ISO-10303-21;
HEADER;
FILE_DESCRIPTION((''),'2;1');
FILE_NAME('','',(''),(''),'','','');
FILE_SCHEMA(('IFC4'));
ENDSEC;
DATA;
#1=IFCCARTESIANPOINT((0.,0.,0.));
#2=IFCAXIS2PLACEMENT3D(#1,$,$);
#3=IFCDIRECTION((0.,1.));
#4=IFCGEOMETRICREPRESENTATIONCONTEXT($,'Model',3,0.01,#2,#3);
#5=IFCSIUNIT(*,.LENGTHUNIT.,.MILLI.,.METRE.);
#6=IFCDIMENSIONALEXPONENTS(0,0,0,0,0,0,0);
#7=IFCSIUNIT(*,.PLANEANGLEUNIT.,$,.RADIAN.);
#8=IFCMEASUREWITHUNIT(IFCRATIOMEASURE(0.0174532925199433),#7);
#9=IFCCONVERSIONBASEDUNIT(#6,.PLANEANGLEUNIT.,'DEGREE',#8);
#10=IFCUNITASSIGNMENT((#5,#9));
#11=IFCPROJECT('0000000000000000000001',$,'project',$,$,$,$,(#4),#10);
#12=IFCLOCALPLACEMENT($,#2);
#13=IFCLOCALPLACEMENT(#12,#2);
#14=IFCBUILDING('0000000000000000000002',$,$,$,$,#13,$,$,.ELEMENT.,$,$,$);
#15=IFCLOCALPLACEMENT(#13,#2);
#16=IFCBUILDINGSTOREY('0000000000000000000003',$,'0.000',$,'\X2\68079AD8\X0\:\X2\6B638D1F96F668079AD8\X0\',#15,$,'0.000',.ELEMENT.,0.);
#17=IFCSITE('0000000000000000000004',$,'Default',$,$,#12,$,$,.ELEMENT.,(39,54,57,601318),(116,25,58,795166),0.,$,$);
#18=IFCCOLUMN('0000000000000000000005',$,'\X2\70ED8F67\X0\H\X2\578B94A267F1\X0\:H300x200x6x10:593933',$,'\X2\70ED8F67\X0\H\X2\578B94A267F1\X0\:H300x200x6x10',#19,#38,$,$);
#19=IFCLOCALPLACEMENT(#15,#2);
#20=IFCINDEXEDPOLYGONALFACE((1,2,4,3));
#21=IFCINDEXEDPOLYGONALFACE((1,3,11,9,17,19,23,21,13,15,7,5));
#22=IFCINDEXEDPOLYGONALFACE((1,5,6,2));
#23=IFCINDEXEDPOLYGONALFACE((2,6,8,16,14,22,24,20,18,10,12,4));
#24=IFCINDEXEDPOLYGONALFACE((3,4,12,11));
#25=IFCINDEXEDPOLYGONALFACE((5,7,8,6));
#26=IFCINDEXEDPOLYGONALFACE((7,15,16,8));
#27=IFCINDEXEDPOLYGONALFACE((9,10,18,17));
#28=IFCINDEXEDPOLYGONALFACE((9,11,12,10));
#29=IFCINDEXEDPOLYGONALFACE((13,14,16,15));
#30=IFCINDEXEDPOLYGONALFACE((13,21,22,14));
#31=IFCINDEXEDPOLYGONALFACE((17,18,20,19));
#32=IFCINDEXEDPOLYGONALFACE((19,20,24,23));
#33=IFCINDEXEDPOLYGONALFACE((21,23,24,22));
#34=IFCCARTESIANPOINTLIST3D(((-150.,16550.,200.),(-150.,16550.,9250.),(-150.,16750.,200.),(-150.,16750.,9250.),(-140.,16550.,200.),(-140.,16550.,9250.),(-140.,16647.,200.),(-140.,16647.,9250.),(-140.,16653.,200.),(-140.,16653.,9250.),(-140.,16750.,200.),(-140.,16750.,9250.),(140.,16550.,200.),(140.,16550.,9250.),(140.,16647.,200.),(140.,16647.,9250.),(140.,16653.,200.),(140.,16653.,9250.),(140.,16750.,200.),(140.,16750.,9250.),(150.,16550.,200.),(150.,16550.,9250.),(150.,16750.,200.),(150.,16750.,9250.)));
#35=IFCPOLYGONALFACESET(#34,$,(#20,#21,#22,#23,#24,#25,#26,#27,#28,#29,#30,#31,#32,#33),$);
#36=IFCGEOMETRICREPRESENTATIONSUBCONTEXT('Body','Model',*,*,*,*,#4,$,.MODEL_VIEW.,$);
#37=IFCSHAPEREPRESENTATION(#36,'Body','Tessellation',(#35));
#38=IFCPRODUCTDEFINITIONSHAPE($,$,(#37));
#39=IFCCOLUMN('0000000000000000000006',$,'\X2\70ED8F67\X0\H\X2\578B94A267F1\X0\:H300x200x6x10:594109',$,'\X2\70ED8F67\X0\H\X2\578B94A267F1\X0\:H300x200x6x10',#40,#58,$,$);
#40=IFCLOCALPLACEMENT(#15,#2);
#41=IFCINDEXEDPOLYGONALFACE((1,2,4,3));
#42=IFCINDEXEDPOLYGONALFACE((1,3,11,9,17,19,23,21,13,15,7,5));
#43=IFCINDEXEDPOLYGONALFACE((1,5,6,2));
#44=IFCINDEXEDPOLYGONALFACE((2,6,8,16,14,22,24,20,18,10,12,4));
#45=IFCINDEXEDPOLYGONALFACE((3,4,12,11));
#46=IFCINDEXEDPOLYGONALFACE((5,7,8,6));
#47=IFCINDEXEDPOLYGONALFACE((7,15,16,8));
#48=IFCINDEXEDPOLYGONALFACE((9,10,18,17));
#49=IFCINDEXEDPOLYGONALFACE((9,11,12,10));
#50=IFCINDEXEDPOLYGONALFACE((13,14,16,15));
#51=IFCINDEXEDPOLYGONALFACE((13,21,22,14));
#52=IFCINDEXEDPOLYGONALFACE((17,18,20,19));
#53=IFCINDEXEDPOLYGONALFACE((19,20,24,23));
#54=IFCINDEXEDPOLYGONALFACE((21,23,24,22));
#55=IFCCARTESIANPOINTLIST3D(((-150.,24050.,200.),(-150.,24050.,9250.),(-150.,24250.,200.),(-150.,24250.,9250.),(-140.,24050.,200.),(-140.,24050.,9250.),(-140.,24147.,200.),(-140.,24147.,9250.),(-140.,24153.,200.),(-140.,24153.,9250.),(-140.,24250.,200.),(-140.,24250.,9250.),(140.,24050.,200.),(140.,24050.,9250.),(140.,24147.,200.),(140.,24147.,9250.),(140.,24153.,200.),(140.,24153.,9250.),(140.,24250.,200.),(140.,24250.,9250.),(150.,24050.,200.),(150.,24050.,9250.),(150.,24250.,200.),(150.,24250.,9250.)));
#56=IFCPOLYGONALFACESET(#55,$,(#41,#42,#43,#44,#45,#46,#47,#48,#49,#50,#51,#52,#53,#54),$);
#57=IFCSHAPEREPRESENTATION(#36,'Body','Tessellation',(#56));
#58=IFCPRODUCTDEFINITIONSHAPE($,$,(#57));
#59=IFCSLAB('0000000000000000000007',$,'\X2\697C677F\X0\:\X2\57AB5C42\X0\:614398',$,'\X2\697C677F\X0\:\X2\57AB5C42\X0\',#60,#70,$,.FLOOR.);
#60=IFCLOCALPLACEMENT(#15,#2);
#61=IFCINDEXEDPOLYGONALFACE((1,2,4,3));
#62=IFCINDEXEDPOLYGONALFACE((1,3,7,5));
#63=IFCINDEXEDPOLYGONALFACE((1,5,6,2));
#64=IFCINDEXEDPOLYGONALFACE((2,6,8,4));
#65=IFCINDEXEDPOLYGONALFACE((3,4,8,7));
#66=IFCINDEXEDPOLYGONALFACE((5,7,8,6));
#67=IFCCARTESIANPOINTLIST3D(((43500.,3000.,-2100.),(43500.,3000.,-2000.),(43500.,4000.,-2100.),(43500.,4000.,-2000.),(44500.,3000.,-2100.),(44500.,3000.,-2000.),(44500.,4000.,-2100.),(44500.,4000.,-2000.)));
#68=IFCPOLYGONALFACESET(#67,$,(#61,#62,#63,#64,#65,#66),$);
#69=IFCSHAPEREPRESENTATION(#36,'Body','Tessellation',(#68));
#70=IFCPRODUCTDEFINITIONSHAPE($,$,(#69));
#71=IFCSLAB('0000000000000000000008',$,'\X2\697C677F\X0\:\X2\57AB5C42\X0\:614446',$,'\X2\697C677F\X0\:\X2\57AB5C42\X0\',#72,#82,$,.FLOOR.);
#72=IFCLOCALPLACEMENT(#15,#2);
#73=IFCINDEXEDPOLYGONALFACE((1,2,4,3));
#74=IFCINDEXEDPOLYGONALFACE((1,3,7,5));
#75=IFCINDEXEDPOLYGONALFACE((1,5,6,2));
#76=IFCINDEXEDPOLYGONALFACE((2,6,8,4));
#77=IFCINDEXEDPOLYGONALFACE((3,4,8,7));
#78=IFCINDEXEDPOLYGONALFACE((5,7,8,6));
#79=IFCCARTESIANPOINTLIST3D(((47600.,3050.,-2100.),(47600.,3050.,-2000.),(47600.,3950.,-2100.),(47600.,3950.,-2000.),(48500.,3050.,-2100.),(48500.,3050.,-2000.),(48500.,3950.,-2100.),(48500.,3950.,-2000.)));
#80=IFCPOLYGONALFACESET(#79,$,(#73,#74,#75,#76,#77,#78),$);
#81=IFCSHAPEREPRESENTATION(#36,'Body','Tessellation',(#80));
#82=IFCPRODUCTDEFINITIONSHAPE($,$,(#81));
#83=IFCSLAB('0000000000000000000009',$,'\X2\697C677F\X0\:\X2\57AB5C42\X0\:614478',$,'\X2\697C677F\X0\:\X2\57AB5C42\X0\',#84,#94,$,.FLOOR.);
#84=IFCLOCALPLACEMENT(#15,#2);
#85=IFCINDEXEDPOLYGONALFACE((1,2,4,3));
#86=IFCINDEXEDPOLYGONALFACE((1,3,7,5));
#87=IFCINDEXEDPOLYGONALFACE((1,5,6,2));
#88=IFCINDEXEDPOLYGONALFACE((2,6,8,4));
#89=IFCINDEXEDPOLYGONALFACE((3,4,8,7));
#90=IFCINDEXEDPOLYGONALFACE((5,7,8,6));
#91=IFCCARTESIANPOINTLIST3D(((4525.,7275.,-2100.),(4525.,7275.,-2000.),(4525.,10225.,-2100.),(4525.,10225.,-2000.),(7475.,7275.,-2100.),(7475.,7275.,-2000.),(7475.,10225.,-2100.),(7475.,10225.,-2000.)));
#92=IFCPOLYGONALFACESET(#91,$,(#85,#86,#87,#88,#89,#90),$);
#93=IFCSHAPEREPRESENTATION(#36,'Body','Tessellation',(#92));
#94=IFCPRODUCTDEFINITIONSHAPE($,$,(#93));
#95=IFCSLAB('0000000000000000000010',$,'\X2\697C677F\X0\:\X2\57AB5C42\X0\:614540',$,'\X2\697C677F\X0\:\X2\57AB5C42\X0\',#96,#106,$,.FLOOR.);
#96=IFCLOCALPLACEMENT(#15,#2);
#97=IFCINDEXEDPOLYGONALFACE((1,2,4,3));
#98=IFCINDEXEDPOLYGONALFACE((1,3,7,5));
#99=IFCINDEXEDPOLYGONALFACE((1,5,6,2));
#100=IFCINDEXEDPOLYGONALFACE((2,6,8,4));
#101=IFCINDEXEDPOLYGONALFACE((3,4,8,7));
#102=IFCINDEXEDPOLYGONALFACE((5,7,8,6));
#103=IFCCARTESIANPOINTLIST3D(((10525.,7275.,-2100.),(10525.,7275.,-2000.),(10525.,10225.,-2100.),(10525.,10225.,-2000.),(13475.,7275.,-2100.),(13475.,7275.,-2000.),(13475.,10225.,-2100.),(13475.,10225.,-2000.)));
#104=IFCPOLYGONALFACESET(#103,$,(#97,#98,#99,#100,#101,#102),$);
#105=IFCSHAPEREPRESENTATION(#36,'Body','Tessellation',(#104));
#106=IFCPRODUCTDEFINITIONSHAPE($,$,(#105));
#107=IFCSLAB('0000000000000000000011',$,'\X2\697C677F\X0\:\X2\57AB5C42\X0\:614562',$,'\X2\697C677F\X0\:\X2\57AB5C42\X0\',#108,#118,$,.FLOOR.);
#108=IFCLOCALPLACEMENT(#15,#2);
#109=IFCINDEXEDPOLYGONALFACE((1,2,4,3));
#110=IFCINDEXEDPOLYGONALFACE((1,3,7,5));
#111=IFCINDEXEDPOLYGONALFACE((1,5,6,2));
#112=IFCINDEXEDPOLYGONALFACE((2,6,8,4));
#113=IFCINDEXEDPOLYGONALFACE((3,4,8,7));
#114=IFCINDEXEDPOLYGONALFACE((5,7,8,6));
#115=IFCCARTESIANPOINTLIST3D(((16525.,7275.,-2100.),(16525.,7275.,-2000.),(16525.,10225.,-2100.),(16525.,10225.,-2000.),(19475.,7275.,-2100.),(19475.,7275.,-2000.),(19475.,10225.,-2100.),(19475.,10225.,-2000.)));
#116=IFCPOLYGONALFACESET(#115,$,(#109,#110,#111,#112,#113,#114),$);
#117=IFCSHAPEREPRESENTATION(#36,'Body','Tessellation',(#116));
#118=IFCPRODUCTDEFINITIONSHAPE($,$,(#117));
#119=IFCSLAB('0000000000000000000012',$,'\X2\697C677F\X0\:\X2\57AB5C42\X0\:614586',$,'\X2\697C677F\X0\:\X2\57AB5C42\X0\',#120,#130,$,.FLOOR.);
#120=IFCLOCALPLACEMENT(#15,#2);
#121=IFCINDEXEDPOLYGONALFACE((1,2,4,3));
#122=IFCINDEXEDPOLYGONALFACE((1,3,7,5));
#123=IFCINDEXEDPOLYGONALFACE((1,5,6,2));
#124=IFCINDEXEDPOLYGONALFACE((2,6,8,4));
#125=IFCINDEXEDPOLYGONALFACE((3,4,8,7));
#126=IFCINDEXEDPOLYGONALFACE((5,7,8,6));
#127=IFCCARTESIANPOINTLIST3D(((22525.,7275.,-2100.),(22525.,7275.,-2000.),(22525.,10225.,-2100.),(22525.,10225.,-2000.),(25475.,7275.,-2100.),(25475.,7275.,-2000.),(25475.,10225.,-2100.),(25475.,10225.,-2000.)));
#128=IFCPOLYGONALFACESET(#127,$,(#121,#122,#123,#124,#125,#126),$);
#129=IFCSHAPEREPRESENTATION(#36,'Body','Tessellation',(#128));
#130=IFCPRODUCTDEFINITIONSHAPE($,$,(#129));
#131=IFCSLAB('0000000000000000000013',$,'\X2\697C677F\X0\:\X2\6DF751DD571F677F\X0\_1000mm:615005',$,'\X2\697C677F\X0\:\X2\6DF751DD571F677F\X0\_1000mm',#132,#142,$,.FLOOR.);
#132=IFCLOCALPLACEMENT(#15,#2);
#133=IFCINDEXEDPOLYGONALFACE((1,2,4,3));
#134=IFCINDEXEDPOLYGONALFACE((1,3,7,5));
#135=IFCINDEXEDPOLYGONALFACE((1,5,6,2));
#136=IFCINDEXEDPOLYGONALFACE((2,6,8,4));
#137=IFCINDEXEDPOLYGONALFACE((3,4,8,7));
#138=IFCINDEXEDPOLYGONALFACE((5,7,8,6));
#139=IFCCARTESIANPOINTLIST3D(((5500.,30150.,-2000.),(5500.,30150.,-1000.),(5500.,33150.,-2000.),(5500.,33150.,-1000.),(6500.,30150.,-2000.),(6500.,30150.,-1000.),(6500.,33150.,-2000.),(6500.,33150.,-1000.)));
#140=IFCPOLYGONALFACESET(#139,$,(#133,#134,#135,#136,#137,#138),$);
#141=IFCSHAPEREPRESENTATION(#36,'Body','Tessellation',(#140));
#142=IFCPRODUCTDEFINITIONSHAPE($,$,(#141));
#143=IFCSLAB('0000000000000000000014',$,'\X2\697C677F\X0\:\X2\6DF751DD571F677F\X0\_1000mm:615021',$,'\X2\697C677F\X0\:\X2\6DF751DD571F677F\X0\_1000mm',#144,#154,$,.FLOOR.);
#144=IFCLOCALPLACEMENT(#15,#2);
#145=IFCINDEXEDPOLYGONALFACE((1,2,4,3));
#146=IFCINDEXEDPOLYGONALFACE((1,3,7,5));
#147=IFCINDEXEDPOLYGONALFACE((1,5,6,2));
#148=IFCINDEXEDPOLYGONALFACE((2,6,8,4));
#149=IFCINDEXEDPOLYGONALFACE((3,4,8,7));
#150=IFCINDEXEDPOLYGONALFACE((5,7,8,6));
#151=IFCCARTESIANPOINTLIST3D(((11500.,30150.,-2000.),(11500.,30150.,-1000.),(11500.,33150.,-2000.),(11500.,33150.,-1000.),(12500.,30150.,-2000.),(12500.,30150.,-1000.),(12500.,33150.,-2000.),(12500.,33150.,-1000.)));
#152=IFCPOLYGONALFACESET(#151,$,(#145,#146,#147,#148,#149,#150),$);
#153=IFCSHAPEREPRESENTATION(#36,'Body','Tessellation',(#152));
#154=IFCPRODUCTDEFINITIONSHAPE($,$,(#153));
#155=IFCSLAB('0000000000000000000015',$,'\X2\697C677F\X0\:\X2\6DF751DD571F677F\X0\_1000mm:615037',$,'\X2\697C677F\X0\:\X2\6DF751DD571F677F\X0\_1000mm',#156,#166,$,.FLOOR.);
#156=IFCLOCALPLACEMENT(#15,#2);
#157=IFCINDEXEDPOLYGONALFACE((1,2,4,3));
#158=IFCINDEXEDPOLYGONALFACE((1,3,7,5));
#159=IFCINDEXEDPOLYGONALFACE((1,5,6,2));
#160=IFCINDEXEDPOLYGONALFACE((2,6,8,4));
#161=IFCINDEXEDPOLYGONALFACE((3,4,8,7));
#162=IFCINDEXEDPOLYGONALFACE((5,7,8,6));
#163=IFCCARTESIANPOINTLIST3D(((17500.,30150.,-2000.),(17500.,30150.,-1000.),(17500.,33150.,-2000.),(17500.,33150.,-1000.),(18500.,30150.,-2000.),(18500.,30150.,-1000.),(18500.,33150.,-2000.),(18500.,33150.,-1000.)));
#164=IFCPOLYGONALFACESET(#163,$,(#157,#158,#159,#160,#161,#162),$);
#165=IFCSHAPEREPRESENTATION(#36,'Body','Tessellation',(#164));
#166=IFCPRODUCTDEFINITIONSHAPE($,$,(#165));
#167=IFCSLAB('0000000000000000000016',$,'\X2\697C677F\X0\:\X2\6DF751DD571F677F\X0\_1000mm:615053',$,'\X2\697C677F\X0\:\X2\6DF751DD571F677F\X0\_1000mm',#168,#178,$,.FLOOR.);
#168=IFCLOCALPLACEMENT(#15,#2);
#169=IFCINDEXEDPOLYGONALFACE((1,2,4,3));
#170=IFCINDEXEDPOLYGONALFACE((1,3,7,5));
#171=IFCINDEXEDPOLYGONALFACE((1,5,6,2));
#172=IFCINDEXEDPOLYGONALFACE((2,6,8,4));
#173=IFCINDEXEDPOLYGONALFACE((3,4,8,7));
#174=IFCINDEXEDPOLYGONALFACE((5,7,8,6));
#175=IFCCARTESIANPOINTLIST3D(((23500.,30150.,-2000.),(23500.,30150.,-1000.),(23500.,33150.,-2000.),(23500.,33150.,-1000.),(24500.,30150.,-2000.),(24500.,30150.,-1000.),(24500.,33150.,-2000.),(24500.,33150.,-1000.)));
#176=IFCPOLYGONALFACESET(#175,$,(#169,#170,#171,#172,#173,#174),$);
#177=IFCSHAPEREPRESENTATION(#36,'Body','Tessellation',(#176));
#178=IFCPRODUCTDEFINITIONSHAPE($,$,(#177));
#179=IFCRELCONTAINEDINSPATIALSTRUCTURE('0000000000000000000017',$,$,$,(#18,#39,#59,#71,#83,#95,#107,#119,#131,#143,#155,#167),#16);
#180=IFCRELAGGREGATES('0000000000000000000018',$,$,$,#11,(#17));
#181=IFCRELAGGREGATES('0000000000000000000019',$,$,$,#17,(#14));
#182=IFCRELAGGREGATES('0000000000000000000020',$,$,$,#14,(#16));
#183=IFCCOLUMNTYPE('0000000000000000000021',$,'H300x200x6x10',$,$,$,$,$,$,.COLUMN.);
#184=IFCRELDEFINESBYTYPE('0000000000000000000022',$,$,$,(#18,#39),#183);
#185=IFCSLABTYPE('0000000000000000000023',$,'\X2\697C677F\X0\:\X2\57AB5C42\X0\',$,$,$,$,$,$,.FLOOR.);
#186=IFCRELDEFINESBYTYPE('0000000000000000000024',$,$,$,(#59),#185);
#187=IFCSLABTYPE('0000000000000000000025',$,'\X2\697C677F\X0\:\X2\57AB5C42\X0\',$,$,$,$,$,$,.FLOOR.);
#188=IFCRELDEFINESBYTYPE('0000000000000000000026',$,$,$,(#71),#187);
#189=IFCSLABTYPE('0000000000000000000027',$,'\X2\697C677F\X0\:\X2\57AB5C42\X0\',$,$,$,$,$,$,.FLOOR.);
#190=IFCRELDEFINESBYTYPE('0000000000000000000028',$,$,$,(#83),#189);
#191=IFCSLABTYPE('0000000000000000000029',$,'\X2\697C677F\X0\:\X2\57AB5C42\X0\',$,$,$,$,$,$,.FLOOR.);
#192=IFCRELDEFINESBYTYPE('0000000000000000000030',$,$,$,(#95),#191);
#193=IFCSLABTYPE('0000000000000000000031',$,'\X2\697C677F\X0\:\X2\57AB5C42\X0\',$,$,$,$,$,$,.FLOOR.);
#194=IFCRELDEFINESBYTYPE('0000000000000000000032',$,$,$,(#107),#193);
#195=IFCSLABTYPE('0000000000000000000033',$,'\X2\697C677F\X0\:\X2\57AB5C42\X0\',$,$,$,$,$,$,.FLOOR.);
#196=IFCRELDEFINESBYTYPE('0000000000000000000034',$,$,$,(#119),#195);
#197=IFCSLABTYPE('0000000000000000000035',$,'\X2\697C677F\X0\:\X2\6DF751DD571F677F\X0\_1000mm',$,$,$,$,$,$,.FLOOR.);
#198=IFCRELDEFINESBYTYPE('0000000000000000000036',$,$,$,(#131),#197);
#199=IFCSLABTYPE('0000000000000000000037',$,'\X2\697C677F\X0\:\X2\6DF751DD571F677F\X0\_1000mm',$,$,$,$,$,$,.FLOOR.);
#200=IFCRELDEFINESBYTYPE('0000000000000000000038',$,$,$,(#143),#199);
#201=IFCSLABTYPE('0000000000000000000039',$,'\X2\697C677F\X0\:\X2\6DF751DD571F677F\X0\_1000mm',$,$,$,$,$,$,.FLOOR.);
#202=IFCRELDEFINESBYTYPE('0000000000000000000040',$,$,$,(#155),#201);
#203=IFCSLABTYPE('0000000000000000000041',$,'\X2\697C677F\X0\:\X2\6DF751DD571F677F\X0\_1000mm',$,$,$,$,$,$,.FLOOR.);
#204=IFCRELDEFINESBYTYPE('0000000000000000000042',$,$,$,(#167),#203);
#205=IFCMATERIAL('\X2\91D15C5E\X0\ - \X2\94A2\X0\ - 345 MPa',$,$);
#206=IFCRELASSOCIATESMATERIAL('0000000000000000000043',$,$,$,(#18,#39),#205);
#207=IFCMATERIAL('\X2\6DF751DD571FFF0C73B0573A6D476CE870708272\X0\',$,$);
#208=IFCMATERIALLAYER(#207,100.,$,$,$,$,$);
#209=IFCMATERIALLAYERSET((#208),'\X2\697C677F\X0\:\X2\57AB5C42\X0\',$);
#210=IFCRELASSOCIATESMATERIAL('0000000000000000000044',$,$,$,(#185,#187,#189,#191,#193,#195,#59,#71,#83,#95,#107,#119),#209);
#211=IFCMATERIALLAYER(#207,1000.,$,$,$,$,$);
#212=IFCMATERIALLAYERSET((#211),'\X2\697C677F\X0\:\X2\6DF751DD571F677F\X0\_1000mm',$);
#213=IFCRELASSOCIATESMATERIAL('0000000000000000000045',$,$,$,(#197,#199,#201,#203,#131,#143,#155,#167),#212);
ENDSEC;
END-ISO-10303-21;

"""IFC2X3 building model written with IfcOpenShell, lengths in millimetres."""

from ifc_helpers import new_model, entity, si_unit, converted_unit, direction, frame, frame_2d, origin, origin_2d_with_axis, place, context, subcontext, project, spatial, polyline, rectangle, outline, extrude, source, transform, mapped, material, layer, layer_set, layer_usage, type_object, type_shapes, element, save


model = new_model("IFC2X3")

# Units and contexts
model_context = context("Model", 3, precision=0.01, world=origin(), true_north=direction((0.0, 1.0)))
body_context = subcontext(model_context, "Body", "Model", "MODEL_VIEW")
ifc_project = project(units=[si_unit("LENGTHUNIT", "METRE", prefix="MILLI"), converted_unit("PLANEANGLEUNIT", "DEGREE", entity("IfcRatioMeasure", 0.0174532925199433), si_unit("PLANEANGLEUNIT", "RADIAN"), dimensions=[0, 0, 0, 0, 0, 0, 0])], contexts=[model_context])

# Site, building, storey
site_placement = place(None, origin())
site = spatial("IfcSite", under=ifc_project, at=site_placement, Name="Default", CompositionType="ELEMENT", RefLatitude=(39, 54, 57, 601318), RefLongitude=(116, 25, 58, 795166), RefElevation=0.0)
building_placement = place(site_placement, origin())
building = spatial("IfcBuilding", under=site, at=building_placement, CompositionType="ELEMENT")
storey_placement = place(building_placement, origin())
storey = spatial("IfcBuildingStorey", under=building, at=storey_placement, Name="0.000", ObjectType="标高:正负零标高", LongName="0.000", CompositionType="ELEMENT", Elevation=0.0)

# Columns
ifc_material_1 = material(Name="金属 - 钢 - 345 MPa")
column_type_1 = type_object("IfcColumnType", Name="H300x200x6x10", PredefinedType="COLUMN")
shared_shape_1 = source(origin(), body_context, "Body", "SweptSolid", [
    extrude(outline(polyline([(140.0, -100.0), (150.0, -100.0), (150.0, 100.0), (140.0, 100.0), (140.0, 3.0), (-140.0, 3.0), (-140.0, 100.0), (-150.0, 100.0), (-150.0, -100.0), (-140.0, -100.0), (-140.0, -3.0), (140.0, -3.0), (140.0, -100.0)])), frame((0.0, 0.0, 200.0), z_axis=(0.0, 0.0, 1.0), x_axis=(0.0, -1.0, 0.0)), (0.0, 0.0, 1.0), 9050.0),
])
type_shapes(column_type_1, [shared_shape_1])
for number, where, z_axis, x_axis, name in (
    (1, (0.0, 16650.0, 0.0), (0.0, 0.0, 1.0), (0.0, 1.0, 0.0), "热轧H型钢柱:H300x200x6x10:593933"),
    (2, (0.0, 24150.0, 0.0), (0.0, 0.0, 1.0), (0.0, 1.0, 0.0), "热轧H型钢柱:H300x200x6x10:594109"),
):
    element("IfcColumn", number, at=place(storey_placement, frame(where, z_axis=z_axis, x_axis=x_axis)), inside=storey, type_object=column_type_1, material=ifc_material_1, Name=name, ObjectType="热轧H型钢柱:H300x200x6x10", context=body_context, shape_type="MappedRepresentation", body=[
        mapped(shared_shape_1, transform((0.0, 0.0, 0.0), scale=1.0)),
    ])

# Slabs
ifc_material_2 = material(Name="混凝土，现场浇注灰色")
ifc_layer_1 = layer(ifc_material_2, 100.0)
ifc_layer_set_1 = layer_set([ifc_layer_1], Name="楼板:垫层")
ifc_layer_usage_1 = layer_usage(ifc_layer_set_1, "AXIS3", "POSITIVE", 0.0)
slab_type_1 = type_object("IfcSlabType", Name="楼板:垫层", PredefinedType="FLOOR", material=ifc_layer_set_1)
slab_1_placement = place(storey_placement, origin())
element("IfcSlab", 3, at=slab_1_placement, inside=storey, type_object=slab_type_1, material=ifc_layer_usage_1, Name="楼板:垫层:614398", ObjectType="楼板:垫层", PredefinedType="FLOOR", context=body_context, shape_type="SweptSolid", body=[
    extrude(rectangle(XDim=1000.0, YDim=1000.0, at=origin_2d_with_axis()), frame((44000.0, 3500.0, -2000.0), z_axis=(0.0, 0.0, -1.0), x_axis=(0.0, 1.0, 0.0)), (0.0, 0.0, 1.0), 100.0),
])
ifc_layer_usage_2 = layer_usage(ifc_layer_set_1, "AXIS3", "POSITIVE", 0.0)
slab_type_2 = type_object("IfcSlabType", Name="楼板:垫层", PredefinedType="FLOOR", material=ifc_layer_set_1)
slab_2_placement = place(storey_placement, origin())
element("IfcSlab", 4, at=slab_2_placement, inside=storey, type_object=slab_type_2, material=ifc_layer_usage_2, Name="楼板:垫层:614446", ObjectType="楼板:垫层", PredefinedType="FLOOR", context=body_context, shape_type="SweptSolid", body=[
    extrude(rectangle(XDim=900.0, YDim=900.0, at=frame_2d((0.0, 0.0), x_axis=(1.0, 0.0))), frame((48050.0, 3500.0, -2000.0), z_axis=(0.0, 0.0, -1.0), x_axis=(0.0, 1.0, 0.0)), (0.0, 0.0, 1.0), 100.0),
])
ifc_layer_usage_3 = layer_usage(ifc_layer_set_1, "AXIS3", "POSITIVE", 0.0)
slab_type_3 = type_object("IfcSlabType", Name="楼板:垫层", PredefinedType="FLOOR", material=ifc_layer_set_1)
slab_3_placement = place(storey_placement, origin())
element("IfcSlab", 5, at=slab_3_placement, inside=storey, type_object=slab_type_3, material=ifc_layer_usage_3, Name="楼板:垫层:614478", ObjectType="楼板:垫层", PredefinedType="FLOOR", context=body_context, shape_type="SweptSolid", body=[
    extrude(rectangle(XDim=2950.0, YDim=2950.0, at=frame_2d((0.0, 0.0), x_axis=(1.0, 0.0))), frame((6000.0, 8750.0, -2000.0), z_axis=(0.0, 0.0, -1.0), x_axis=(0.0, 1.0, 0.0)), (0.0, 0.0, 1.0), 100.0),
])
ifc_layer_usage_4 = layer_usage(ifc_layer_set_1, "AXIS3", "POSITIVE", 0.0)
slab_type_4 = type_object("IfcSlabType", Name="楼板:垫层", PredefinedType="FLOOR", material=ifc_layer_set_1)
slab_4_placement = place(storey_placement, origin())
element("IfcSlab", 6, at=slab_4_placement, inside=storey, type_object=slab_type_4, material=ifc_layer_usage_4, Name="楼板:垫层:614540", ObjectType="楼板:垫层", PredefinedType="FLOOR", context=body_context, shape_type="SweptSolid", body=[
    extrude(rectangle(XDim=2950.0, YDim=2950.0, at=origin_2d_with_axis()), frame((12000.0, 8750.0, -2000.0), z_axis=(0.0, 0.0, -1.0), x_axis=(0.0, 1.0, 0.0)), (0.0, 0.0, 1.0), 100.0),
])
ifc_layer_usage_5 = layer_usage(ifc_layer_set_1, "AXIS3", "POSITIVE", 0.0)
slab_type_5 = type_object("IfcSlabType", Name="楼板:垫层", PredefinedType="FLOOR", material=ifc_layer_set_1)
slab_5_placement = place(storey_placement, origin())
element("IfcSlab", 7, at=slab_5_placement, inside=storey, type_object=slab_type_5, material=ifc_layer_usage_5, Name="楼板:垫层:614562", ObjectType="楼板:垫层", PredefinedType="FLOOR", context=body_context, shape_type="SweptSolid", body=[
    extrude(rectangle(XDim=2950.0, YDim=2950.0, at=origin_2d_with_axis()), frame((18000.0, 8750.0, -2000.0), z_axis=(0.0, 0.0, -1.0), x_axis=(0.0, 1.0, 0.0)), (0.0, 0.0, 1.0), 100.0),
])
ifc_layer_usage_6 = layer_usage(ifc_layer_set_1, "AXIS3", "POSITIVE", 0.0)
slab_type_6 = type_object("IfcSlabType", Name="楼板:垫层", PredefinedType="FLOOR", material=ifc_layer_set_1)
slab_6_placement = place(storey_placement, origin())
element("IfcSlab", 8, at=slab_6_placement, inside=storey, type_object=slab_type_6, material=ifc_layer_usage_6, Name="楼板:垫层:614586", ObjectType="楼板:垫层", PredefinedType="FLOOR", context=body_context, shape_type="SweptSolid", body=[
    extrude(rectangle(XDim=2950.0, YDim=2950.0, at=frame_2d((0.0, 0.0), x_axis=(1.0, 0.0))), frame((24000.0, 8750.0, -2000.0), z_axis=(0.0, 0.0, -1.0), x_axis=(0.0, 1.0, 0.0)), (0.0, 0.0, 1.0), 100.0),
])
ifc_layer_2 = layer(ifc_material_2, 1000.0)
ifc_layer_set_2 = layer_set([ifc_layer_2], Name="楼板:混凝土板_1000mm")
ifc_layer_usage_7 = layer_usage(ifc_layer_set_2, "AXIS3", "POSITIVE", 0.0)
slab_type_7 = type_object("IfcSlabType", Name="楼板:混凝土板_1000mm", PredefinedType="FLOOR", material=ifc_layer_set_2)
slab_7_placement = place(storey_placement, origin())
element("IfcSlab", 9, at=slab_7_placement, inside=storey, type_object=slab_type_7, material=ifc_layer_usage_7, Name="楼板:混凝土板_1000mm:615005", ObjectType="楼板:混凝土板_1000mm", PredefinedType="FLOOR", context=body_context, shape_type="SweptSolid", body=[
    extrude(rectangle(XDim=3000.0, YDim=1000.0, at=frame_2d((0.0, 0.0), x_axis=(1.0, 0.0))), frame((6000.0, 31650.0, -1000.0), z_axis=(0.0, 0.0, -1.0), x_axis=(0.0, 1.0, 0.0)), (0.0, 0.0, 1.0), 1000.0),
])
ifc_layer_usage_8 = layer_usage(ifc_layer_set_2, "AXIS3", "POSITIVE", 0.0)
slab_type_8 = type_object("IfcSlabType", Name="楼板:混凝土板_1000mm", PredefinedType="FLOOR", material=ifc_layer_set_2)
slab_8_placement = place(storey_placement, origin())
element("IfcSlab", 10, at=slab_8_placement, inside=storey, type_object=slab_type_8, material=ifc_layer_usage_8, Name="楼板:混凝土板_1000mm:615021", ObjectType="楼板:混凝土板_1000mm", PredefinedType="FLOOR", context=body_context, shape_type="SweptSolid", body=[
    extrude(rectangle(XDim=3000.0, YDim=1000.0, at=frame_2d((0.0, 0.0), x_axis=(1.0, 0.0))), frame((12000.0, 31650.0, -1000.0), z_axis=(0.0, 0.0, -1.0), x_axis=(0.0, 1.0, 0.0)), (0.0, 0.0, 1.0), 1000.0),
])
ifc_layer_usage_9 = layer_usage(ifc_layer_set_2, "AXIS3", "POSITIVE", 0.0)
slab_type_9 = type_object("IfcSlabType", Name="楼板:混凝土板_1000mm", PredefinedType="FLOOR", material=ifc_layer_set_2)
slab_9_placement = place(storey_placement, origin())
element("IfcSlab", 11, at=slab_9_placement, inside=storey, type_object=slab_type_9, material=ifc_layer_usage_9, Name="楼板:混凝土板_1000mm:615037", ObjectType="楼板:混凝土板_1000mm", PredefinedType="FLOOR", context=body_context, shape_type="SweptSolid", body=[
    extrude(rectangle(XDim=3000.0, YDim=1000.0, at=frame_2d((0.0, 0.0), x_axis=(1.0, 0.0))), frame((18000.0, 31650.0, -1000.0), z_axis=(0.0, 0.0, -1.0), x_axis=(0.0, 1.0, 0.0)), (0.0, 0.0, 1.0), 1000.0),
])
ifc_layer_usage_10 = layer_usage(ifc_layer_set_2, "AXIS3", "POSITIVE", 0.0)
slab_type_10 = type_object("IfcSlabType", Name="楼板:混凝土板_1000mm", PredefinedType="FLOOR", material=ifc_layer_set_2)
slab_10_placement = place(storey_placement, origin())
element("IfcSlab", 12, at=slab_10_placement, inside=storey, type_object=slab_type_10, material=ifc_layer_usage_10, Name="楼板:混凝土板_1000mm:615053", ObjectType="楼板:混凝土板_1000mm", PredefinedType="FLOOR", context=body_context, shape_type="SweptSolid", body=[
    extrude(rectangle(XDim=3000.0, YDim=1000.0, at=frame_2d((0.0, 0.0), x_axis=(1.0, 0.0))), frame((24000.0, 31650.0, -1000.0), z_axis=(0.0, 0.0, -1.0), x_axis=(0.0, 1.0, 0.0)), (0.0, 0.0, 1.0), 1000.0),
])

save(model, "model.ifc")
